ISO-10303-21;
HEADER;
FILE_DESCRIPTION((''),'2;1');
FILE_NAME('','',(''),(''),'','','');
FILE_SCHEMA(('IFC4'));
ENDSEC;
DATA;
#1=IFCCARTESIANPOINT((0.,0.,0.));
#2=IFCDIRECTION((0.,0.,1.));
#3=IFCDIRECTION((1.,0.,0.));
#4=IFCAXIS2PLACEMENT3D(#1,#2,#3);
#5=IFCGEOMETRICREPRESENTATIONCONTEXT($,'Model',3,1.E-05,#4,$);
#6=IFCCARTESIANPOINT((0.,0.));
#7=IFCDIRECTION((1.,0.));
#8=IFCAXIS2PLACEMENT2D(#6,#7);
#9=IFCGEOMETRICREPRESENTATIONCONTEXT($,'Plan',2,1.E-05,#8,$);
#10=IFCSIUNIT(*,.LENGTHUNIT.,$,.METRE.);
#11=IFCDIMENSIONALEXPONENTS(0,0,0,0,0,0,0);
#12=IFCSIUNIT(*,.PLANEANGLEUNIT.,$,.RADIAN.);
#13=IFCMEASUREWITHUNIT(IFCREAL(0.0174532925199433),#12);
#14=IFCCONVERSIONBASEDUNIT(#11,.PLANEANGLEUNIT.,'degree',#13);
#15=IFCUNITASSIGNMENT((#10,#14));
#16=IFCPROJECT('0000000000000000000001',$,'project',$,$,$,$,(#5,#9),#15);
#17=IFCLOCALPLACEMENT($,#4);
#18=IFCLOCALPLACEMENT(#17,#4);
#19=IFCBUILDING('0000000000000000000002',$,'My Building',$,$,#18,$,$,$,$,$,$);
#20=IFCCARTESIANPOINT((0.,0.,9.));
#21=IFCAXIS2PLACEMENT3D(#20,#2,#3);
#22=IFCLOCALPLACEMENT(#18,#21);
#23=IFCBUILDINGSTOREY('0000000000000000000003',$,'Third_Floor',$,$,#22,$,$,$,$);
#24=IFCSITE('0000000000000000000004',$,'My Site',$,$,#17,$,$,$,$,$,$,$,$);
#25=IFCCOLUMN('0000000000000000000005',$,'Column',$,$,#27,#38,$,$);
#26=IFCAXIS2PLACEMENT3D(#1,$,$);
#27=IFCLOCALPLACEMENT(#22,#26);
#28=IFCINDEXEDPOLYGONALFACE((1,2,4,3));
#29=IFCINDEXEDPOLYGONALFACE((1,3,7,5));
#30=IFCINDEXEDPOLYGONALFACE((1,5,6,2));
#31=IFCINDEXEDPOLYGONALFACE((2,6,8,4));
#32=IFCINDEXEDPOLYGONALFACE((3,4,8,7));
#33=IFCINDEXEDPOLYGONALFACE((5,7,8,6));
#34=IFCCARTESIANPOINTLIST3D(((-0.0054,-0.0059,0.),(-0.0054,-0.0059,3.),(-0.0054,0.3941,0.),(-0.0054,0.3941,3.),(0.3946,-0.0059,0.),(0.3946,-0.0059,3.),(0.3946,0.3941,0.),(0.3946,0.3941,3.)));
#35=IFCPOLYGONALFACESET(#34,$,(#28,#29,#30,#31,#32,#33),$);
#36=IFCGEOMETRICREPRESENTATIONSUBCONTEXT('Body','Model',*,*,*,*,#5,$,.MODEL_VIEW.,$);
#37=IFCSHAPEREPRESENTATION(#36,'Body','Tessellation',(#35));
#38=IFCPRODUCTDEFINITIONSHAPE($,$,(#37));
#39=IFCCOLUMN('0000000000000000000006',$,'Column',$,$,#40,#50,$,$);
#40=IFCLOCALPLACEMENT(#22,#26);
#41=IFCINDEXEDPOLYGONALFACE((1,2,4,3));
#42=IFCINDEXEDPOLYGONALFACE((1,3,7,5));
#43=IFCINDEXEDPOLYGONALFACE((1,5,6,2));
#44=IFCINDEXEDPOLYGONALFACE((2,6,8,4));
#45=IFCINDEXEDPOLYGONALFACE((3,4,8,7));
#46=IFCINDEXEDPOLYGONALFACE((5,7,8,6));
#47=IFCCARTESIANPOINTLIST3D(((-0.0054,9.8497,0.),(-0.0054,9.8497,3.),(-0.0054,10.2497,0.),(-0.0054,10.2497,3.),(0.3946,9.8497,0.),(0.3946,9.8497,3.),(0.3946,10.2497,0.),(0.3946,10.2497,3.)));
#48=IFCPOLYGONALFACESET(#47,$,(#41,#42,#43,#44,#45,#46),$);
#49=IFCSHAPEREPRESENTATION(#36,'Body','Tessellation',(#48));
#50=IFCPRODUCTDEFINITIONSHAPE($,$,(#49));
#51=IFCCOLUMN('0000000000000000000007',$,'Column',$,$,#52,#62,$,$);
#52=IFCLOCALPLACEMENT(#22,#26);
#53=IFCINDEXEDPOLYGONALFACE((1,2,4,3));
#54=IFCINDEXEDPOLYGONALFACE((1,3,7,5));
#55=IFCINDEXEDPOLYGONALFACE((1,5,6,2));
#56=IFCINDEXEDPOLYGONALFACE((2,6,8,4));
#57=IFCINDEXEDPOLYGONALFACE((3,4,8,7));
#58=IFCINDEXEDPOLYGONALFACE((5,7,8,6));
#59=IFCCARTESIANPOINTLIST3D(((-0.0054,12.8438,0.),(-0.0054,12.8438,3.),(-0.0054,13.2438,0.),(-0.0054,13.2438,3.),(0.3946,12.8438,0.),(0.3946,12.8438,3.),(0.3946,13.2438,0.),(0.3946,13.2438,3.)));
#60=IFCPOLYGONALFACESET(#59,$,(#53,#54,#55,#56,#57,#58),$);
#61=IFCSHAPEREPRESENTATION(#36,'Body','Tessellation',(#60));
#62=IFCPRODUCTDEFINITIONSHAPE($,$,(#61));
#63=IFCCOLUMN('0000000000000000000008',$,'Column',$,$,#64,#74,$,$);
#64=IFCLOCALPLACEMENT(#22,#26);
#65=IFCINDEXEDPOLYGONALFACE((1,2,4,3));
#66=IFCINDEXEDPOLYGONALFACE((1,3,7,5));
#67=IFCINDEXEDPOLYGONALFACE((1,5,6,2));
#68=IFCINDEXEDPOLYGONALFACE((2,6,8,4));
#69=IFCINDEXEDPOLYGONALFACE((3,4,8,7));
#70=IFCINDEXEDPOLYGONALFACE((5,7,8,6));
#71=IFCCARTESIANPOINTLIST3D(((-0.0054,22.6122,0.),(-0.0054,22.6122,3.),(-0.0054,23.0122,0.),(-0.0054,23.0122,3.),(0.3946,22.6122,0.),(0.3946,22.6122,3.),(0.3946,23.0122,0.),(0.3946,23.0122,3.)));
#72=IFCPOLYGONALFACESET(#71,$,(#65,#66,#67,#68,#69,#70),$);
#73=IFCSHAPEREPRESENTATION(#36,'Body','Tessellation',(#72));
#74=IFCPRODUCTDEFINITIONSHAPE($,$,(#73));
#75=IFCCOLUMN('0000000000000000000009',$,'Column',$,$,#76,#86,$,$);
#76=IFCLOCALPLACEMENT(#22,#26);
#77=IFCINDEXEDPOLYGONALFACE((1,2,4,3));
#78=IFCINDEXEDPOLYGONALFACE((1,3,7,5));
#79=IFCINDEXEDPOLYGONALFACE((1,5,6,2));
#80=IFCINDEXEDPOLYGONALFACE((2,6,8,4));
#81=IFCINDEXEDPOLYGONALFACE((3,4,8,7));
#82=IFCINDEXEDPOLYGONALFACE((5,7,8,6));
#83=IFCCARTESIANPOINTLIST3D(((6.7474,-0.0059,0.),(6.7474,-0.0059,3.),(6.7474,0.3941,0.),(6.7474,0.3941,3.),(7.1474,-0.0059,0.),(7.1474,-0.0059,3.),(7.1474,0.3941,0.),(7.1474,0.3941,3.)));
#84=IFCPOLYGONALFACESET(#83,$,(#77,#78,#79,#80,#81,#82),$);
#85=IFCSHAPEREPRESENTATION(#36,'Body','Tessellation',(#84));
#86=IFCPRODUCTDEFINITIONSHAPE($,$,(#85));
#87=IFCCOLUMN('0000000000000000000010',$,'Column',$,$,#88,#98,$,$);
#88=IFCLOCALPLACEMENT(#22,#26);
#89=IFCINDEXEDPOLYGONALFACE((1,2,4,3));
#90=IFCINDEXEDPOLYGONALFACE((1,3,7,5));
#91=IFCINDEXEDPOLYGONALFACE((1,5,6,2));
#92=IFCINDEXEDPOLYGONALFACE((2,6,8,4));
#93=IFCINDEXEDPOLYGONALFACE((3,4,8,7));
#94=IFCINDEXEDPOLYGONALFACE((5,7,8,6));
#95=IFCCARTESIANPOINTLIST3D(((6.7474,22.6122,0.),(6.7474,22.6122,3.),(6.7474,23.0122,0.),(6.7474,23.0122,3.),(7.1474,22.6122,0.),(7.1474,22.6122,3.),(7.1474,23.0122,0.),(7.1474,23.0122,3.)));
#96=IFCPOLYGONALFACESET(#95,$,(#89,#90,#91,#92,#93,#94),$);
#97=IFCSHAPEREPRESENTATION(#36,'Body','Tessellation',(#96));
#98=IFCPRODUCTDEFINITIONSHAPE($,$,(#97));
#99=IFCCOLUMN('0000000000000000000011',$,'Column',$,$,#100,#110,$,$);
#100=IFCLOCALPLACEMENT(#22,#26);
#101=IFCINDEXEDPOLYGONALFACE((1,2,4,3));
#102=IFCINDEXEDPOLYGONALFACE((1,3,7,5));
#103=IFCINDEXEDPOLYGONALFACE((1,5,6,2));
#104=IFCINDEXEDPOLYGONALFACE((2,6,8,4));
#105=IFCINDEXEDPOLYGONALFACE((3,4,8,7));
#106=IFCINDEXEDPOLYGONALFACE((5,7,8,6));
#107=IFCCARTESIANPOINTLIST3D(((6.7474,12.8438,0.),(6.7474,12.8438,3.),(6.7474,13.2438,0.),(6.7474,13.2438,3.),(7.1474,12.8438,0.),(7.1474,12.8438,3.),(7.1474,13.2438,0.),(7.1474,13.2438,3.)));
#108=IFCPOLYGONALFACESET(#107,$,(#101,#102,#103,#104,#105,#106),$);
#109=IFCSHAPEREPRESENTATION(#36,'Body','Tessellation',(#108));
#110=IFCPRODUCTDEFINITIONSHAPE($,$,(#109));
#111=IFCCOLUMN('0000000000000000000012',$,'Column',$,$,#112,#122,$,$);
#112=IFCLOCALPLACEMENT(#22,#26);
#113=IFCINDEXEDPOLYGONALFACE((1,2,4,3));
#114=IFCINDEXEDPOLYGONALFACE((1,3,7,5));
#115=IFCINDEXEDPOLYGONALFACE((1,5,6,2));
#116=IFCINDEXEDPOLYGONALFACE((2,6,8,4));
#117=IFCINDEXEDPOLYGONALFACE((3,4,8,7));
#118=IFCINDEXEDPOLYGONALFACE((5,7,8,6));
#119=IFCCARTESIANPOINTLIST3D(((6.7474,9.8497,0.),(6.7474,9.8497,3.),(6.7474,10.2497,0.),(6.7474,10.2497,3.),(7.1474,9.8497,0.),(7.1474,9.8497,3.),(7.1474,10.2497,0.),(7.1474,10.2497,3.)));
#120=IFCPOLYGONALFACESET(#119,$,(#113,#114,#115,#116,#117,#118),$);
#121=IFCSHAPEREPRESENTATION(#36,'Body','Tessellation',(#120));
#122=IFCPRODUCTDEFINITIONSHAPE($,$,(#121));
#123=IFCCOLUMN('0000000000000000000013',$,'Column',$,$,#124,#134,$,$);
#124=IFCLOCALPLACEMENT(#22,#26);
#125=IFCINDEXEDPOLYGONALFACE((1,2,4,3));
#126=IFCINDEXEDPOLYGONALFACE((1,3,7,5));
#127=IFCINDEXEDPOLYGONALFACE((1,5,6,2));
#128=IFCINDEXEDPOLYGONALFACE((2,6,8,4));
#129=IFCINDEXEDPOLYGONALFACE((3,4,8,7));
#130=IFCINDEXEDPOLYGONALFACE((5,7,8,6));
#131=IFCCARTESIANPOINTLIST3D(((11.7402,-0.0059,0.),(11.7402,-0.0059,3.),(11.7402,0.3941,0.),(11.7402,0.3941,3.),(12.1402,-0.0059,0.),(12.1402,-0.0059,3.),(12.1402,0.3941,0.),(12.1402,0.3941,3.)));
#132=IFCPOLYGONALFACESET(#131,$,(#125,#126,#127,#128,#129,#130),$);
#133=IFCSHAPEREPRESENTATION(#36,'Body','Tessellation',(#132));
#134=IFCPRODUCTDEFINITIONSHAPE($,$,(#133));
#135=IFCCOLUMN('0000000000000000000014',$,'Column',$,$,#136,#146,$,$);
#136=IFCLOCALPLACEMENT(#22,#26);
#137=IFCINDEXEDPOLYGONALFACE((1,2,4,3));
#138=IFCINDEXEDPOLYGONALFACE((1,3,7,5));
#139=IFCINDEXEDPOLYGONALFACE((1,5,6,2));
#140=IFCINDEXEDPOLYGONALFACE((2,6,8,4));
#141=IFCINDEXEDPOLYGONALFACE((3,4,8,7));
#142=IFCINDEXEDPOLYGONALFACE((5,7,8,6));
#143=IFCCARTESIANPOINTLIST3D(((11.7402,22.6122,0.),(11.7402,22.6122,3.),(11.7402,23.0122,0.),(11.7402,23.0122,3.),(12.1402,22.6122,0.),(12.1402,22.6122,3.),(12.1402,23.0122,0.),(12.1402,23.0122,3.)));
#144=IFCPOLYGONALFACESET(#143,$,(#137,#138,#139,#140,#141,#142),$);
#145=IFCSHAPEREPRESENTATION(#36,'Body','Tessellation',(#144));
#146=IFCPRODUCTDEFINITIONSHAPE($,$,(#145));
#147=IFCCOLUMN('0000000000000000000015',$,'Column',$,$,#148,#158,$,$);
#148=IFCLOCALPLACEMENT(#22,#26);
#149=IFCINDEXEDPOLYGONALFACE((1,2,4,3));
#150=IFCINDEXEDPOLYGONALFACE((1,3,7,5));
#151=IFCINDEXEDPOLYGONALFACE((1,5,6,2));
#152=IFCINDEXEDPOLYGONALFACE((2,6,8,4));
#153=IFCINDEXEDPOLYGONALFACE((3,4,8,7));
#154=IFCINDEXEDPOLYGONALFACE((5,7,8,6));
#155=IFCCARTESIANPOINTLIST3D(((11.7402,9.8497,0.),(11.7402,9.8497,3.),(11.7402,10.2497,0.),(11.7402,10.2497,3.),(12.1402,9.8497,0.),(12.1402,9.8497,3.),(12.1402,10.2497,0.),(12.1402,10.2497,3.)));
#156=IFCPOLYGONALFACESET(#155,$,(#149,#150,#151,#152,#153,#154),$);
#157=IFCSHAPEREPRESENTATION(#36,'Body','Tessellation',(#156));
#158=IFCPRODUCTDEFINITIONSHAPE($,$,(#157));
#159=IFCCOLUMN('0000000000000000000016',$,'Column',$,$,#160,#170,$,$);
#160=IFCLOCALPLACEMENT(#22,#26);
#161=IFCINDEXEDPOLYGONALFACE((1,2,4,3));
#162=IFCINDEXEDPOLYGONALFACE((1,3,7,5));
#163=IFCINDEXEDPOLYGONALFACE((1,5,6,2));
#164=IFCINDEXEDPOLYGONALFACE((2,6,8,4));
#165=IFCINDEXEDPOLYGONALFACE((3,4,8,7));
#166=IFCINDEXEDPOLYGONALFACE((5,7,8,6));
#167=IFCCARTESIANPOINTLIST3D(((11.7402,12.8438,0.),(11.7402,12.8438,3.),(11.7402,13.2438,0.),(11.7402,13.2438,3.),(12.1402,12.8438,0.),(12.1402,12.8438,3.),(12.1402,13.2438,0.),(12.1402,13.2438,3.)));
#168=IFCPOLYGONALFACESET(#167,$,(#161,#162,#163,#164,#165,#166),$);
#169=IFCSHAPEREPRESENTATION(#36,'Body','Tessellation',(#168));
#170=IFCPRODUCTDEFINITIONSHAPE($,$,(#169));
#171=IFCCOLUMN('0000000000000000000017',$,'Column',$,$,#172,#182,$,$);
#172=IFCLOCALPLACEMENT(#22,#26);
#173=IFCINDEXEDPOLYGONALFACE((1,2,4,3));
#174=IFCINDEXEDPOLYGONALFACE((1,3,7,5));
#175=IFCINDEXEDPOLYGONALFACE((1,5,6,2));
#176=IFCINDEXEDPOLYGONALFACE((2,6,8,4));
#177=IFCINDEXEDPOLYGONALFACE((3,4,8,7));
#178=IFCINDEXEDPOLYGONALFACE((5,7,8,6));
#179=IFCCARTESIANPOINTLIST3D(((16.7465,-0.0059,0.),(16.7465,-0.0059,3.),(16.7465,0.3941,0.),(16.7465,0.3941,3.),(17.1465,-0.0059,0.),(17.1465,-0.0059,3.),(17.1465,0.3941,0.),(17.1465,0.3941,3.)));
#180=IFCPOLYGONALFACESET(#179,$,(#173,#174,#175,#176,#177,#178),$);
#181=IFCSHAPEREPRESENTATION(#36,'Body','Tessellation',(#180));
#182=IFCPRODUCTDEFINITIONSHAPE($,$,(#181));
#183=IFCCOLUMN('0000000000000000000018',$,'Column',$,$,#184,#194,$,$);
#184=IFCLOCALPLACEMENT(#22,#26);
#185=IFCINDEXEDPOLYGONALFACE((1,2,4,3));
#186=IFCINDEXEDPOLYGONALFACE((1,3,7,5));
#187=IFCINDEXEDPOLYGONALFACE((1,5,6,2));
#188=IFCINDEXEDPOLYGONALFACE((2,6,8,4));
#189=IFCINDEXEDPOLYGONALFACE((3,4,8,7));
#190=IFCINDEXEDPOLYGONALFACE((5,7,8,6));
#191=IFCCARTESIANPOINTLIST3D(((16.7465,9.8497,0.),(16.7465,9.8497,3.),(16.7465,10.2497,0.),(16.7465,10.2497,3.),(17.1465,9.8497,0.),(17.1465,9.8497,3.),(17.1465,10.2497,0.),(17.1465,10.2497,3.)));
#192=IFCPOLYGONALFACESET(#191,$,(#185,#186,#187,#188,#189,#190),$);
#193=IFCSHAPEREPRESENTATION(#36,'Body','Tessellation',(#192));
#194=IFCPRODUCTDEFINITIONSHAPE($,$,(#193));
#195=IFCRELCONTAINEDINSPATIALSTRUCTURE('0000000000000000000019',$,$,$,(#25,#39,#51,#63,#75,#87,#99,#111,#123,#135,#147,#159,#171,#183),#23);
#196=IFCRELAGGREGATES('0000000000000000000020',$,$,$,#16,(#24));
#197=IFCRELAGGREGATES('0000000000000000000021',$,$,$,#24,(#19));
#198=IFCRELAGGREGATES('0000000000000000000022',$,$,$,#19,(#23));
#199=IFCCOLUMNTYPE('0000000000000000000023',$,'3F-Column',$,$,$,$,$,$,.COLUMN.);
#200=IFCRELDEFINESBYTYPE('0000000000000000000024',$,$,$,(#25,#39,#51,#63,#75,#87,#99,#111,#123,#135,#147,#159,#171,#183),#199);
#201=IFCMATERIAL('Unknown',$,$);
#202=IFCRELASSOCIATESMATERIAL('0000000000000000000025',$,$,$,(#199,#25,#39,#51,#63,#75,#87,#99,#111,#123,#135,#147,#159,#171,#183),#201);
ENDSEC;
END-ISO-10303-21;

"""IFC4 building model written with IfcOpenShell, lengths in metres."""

from ifc_helpers import new_model, entity, si_unit, converted_unit, frame, origin_with_axes, origin_2d_with_axis, place, context, subcontext, project, spatial, rectangle, extrude, material, material_profile, profile_set, profile_usage, type_object, element, save


model = new_model("IFC4")

# Units and contexts
model_context = context("Model", 3, precision=1e-05, world=origin_with_axes())
plan_context = context("Plan", 2, precision=1e-05, world=origin_2d_with_axis())
body_context = subcontext(model_context, "Body", "Model", "MODEL_VIEW")
ifc_project = project(units=[si_unit("LENGTHUNIT", "METRE"), converted_unit("PLANEANGLEUNIT", "degree", entity("IfcReal", 0.0174532925199433), si_unit("PLANEANGLEUNIT", "RADIAN"), dimensions=[0, 0, 0, 0, 0, 0, 0])], contexts=[model_context, plan_context])

# Site, building, storey
site_placement = place(None, origin_with_axes())
site = spatial("IfcSite", under=ifc_project, at=site_placement, Name="My Site")
building_placement = place(site_placement, origin_with_axes())
building = spatial("IfcBuilding", under=site, at=building_placement, Name="My Building")
storey_placement = place(building_placement, frame((0.0, 0.0, 9.0), z_axis=(0.0, 0.0, 1.0), x_axis=(1.0, 0.0, 0.0)))
storey = spatial("IfcBuildingStorey", under=building, at=storey_placement, Name="Third_Floor")

# Columns
ifc_material = material(Name="Unknown")
ifc_material_profile_1 = material_profile(ifc_material, rectangle(XDim=0.4, YDim=0.4))
ifc_profile_set_1 = profile_set([ifc_material_profile_1])
ifc_profile_usage_1 = profile_usage(ifc_profile_set_1, cardinal=8)
column_type = type_object("IfcColumnType", Name="3F-Column", PredefinedType="COLUMN", material=ifc_profile_set_1)
column_1_placement = place(storey_placement, frame((0.1946, 0.3941, 0.0), z_axis=(0.0, 0.0, 1.0), x_axis=(1.0, 0.0, 0.0)))
element("IfcColumn", 1, at=column_1_placement, inside=storey, type_object=column_type, material=ifc_profile_usage_1, Name="Column", context=body_context, shape_type="SweptSolid", body=[
    extrude(rectangle(XDim=0.4, YDim=0.4), frame((0.0, -0.2, 0.0), z_axis=(0.0, 0.0, 1.0), x_axis=(1.0, 0.0, 0.0)), (0.0, 0.0, 1.0), 3.0),
])
ifc_profile_usage_2 = profile_usage(ifc_profile_set_1, cardinal=8)
column_2_placement = place(storey_placement, frame((0.1946, 10.2497, 0.0), z_axis=(0.0, 0.0, 1.0), x_axis=(1.0, 0.0, 0.0)))
element("IfcColumn", 2, at=column_2_placement, inside=storey, type_object=column_type, material=ifc_profile_usage_2, Name="Column", context=body_context, shape_type="SweptSolid", body=[
    extrude(rectangle(XDim=0.4, YDim=0.4), frame((0.0, -0.2, 0.0), z_axis=(0.0, 0.0, 1.0), x_axis=(1.0, 0.0, 0.0)), (0.0, 0.0, 1.0), 3.0),
])
ifc_profile_usage_3 = profile_usage(ifc_profile_set_1, cardinal=8)
column_3_placement = place(storey_placement, frame((0.1946, 13.2438, 0.0), z_axis=(0.0, 0.0, 1.0), x_axis=(1.0, 0.0, 0.0)))
element("IfcColumn", 3, at=column_3_placement, inside=storey, type_object=column_type, material=ifc_profile_usage_3, Name="Column", context=body_context, shape_type="SweptSolid", body=[
    extrude(rectangle(XDim=0.4, YDim=0.4), frame((0.0, -0.2, 0.0), z_axis=(0.0, 0.0, 1.0), x_axis=(1.0, 0.0, 0.0)), (0.0, 0.0, 1.0), 3.0),
])
ifc_profile_usage_4 = profile_usage(ifc_profile_set_1, cardinal=8)
column_4_placement = place(storey_placement, frame((0.1946, 23.0122, 0.0), z_axis=(0.0, 0.0, 1.0), x_axis=(1.0, 0.0, 0.0)))
element("IfcColumn", 4, at=column_4_placement, inside=storey, type_object=column_type, material=ifc_profile_usage_4, Name="Column", context=body_context, shape_type="SweptSolid", body=[
    extrude(rectangle(XDim=0.4, YDim=0.4), frame((0.0, -0.2, 0.0), z_axis=(0.0, 0.0, 1.0), x_axis=(1.0, 0.0, 0.0)), (0.0, 0.0, 1.0), 3.0),
])
ifc_profile_usage_5 = profile_usage(ifc_profile_set_1, cardinal=8)
column_5_placement = place(storey_placement, frame((6.9474, 0.3941, 0.0), z_axis=(0.0, 0.0, 1.0), x_axis=(1.0, 0.0, 0.0)))
element("IfcColumn", 5, at=column_5_placement, inside=storey, type_object=column_type, material=ifc_profile_usage_5, Name="Column", context=body_context, shape_type="SweptSolid", body=[
    extrude(rectangle(XDim=0.4, YDim=0.4), frame((0.0, -0.2, 0.0), z_axis=(0.0, 0.0, 1.0), x_axis=(1.0, 0.0, 0.0)), (0.0, 0.0, 1.0), 3.0),
])
ifc_profile_usage_6 = profile_usage(ifc_profile_set_1, cardinal=8)
column_6_placement = place(storey_placement, frame((6.9474, 23.0122, 0.0), z_axis=(0.0, 0.0, 1.0), x_axis=(1.0, 0.0, 0.0)))
element("IfcColumn", 6, at=column_6_placement, inside=storey, type_object=column_type, material=ifc_profile_usage_6, Name="Column", context=body_context, shape_type="SweptSolid", body=[
    extrude(rectangle(XDim=0.4, YDim=0.4), frame((0.0, -0.2, 0.0), z_axis=(0.0, 0.0, 1.0), x_axis=(1.0, 0.0, 0.0)), (0.0, 0.0, 1.0), 3.0),
])
ifc_profile_usage_7 = profile_usage(ifc_profile_set_1, cardinal=8)
column_7_placement = place(storey_placement, frame((6.9474, 13.2438, 0.0), z_axis=(0.0, 0.0, 1.0), x_axis=(1.0, 0.0, 0.0)))
element("IfcColumn", 7, at=column_7_placement, inside=storey, type_object=column_type, material=ifc_profile_usage_7, Name="Column", context=body_context, shape_type="SweptSolid", body=[
    extrude(rectangle(XDim=0.4, YDim=0.4), frame((0.0, -0.2, 0.0), z_axis=(0.0, 0.0, 1.0), x_axis=(1.0, 0.0, 0.0)), (0.0, 0.0, 1.0), 3.0),
])
ifc_profile_usage_8 = profile_usage(ifc_profile_set_1, cardinal=8)
column_8_placement = place(storey_placement, frame((6.9474, 10.2497, 0.0), z_axis=(0.0, 0.0, 1.0), x_axis=(1.0, 0.0, 0.0)))
element("IfcColumn", 8, at=column_8_placement, inside=storey, type_object=column_type, material=ifc_profile_usage_8, Name="Column", context=body_context, shape_type="SweptSolid", body=[
    extrude(rectangle(XDim=0.4, YDim=0.4), frame((0.0, -0.2, 0.0), z_axis=(0.0, 0.0, 1.0), x_axis=(1.0, 0.0, 0.0)), (0.0, 0.0, 1.0), 3.0),
])
ifc_profile_usage_9 = profile_usage(ifc_profile_set_1, cardinal=8)
column_9_placement = place(storey_placement, frame((11.9402, 0.3941, 0.0), z_axis=(0.0, 0.0, 1.0), x_axis=(1.0, 0.0, 0.0)))
element("IfcColumn", 9, at=column_9_placement, inside=storey, type_object=column_type, material=ifc_profile_usage_9, Name="Column", context=body_context, shape_type="SweptSolid", body=[
    extrude(rectangle(XDim=0.4, YDim=0.4), frame((0.0, -0.2, 0.0), z_axis=(0.0, 0.0, 1.0), x_axis=(1.0, 0.0, 0.0)), (0.0, 0.0, 1.0), 3.0),
])
ifc_profile_usage_10 = profile_usage(ifc_profile_set_1, cardinal=8)
column_10_placement = place(storey_placement, frame((11.9402, 23.0122, 0.0), z_axis=(0.0, 0.0, 1.0), x_axis=(1.0, 0.0, 0.0)))
element("IfcColumn", 10, at=column_10_placement, inside=storey, type_object=column_type, material=ifc_profile_usage_10, Name="Column", context=body_context, shape_type="SweptSolid", body=[
    extrude(rectangle(XDim=0.4, YDim=0.4), frame((0.0, -0.2, 0.0), z_axis=(0.0, 0.0, 1.0), x_axis=(1.0, 0.0, 0.0)), (0.0, 0.0, 1.0), 3.0),
])
ifc_profile_usage_11 = profile_usage(ifc_profile_set_1, cardinal=8)
column_11_placement = place(storey_placement, frame((11.9402, 10.2497, 0.0), z_axis=(0.0, 0.0, 1.0), x_axis=(1.0, 0.0, 0.0)))
element("IfcColumn", 11, at=column_11_placement, inside=storey, type_object=column_type, material=ifc_profile_usage_11, Name="Column", context=body_context, shape_type="SweptSolid", body=[
    extrude(rectangle(XDim=0.4, YDim=0.4), frame((0.0, -0.2, 0.0), z_axis=(0.0, 0.0, 1.0), x_axis=(1.0, 0.0, 0.0)), (0.0, 0.0, 1.0), 3.0),
])
ifc_profile_usage_12 = profile_usage(ifc_profile_set_1, cardinal=8)
column_12_placement = place(storey_placement, frame((11.9402, 13.2438, 0.0), z_axis=(0.0, 0.0, 1.0), x_axis=(1.0, 0.0, 0.0)))
element("IfcColumn", 12, at=column_12_placement, inside=storey, type_object=column_type, material=ifc_profile_usage_12, Name="Column", context=body_context, shape_type="SweptSolid", body=[
    extrude(rectangle(XDim=0.4, YDim=0.4), frame((0.0, -0.2, 0.0), z_axis=(0.0, 0.0, 1.0), x_axis=(1.0, 0.0, 0.0)), (0.0, 0.0, 1.0), 3.0),
])
ifc_profile_usage_13 = profile_usage(ifc_profile_set_1, cardinal=8)
column_13_placement = place(storey_placement, frame((16.9465, 0.3941, 0.0), z_axis=(0.0, 0.0, 1.0), x_axis=(1.0, 0.0, 0.0)))
element("IfcColumn", 13, at=column_13_placement, inside=storey, type_object=column_type, material=ifc_profile_usage_13, Name="Column", context=body_context, shape_type="SweptSolid", body=[
    extrude(rectangle(XDim=0.4, YDim=0.4), frame((0.0, -0.2, 0.0), z_axis=(0.0, 0.0, 1.0), x_axis=(1.0, 0.0, 0.0)), (0.0, 0.0, 1.0), 3.0),
])
ifc_profile_usage_14 = profile_usage(ifc_profile_set_1, cardinal=8)
column_14_placement = place(storey_placement, frame((16.9465, 10.2497, 0.0), z_axis=(0.0, 0.0, 1.0), x_axis=(1.0, 0.0, 0.0)))
element("IfcColumn", 14, at=column_14_placement, inside=storey, type_object=column_type, material=ifc_profile_usage_14, Name="Column", context=body_context, shape_type="SweptSolid", body=[
    extrude(rectangle(XDim=0.4, YDim=0.4), frame((0.0, -0.2, 0.0), z_axis=(0.0, 0.0, 1.0), x_axis=(1.0, 0.0, 0.0)), (0.0, 0.0, 1.0), 3.0),
])

save(model, "model.ifc")
